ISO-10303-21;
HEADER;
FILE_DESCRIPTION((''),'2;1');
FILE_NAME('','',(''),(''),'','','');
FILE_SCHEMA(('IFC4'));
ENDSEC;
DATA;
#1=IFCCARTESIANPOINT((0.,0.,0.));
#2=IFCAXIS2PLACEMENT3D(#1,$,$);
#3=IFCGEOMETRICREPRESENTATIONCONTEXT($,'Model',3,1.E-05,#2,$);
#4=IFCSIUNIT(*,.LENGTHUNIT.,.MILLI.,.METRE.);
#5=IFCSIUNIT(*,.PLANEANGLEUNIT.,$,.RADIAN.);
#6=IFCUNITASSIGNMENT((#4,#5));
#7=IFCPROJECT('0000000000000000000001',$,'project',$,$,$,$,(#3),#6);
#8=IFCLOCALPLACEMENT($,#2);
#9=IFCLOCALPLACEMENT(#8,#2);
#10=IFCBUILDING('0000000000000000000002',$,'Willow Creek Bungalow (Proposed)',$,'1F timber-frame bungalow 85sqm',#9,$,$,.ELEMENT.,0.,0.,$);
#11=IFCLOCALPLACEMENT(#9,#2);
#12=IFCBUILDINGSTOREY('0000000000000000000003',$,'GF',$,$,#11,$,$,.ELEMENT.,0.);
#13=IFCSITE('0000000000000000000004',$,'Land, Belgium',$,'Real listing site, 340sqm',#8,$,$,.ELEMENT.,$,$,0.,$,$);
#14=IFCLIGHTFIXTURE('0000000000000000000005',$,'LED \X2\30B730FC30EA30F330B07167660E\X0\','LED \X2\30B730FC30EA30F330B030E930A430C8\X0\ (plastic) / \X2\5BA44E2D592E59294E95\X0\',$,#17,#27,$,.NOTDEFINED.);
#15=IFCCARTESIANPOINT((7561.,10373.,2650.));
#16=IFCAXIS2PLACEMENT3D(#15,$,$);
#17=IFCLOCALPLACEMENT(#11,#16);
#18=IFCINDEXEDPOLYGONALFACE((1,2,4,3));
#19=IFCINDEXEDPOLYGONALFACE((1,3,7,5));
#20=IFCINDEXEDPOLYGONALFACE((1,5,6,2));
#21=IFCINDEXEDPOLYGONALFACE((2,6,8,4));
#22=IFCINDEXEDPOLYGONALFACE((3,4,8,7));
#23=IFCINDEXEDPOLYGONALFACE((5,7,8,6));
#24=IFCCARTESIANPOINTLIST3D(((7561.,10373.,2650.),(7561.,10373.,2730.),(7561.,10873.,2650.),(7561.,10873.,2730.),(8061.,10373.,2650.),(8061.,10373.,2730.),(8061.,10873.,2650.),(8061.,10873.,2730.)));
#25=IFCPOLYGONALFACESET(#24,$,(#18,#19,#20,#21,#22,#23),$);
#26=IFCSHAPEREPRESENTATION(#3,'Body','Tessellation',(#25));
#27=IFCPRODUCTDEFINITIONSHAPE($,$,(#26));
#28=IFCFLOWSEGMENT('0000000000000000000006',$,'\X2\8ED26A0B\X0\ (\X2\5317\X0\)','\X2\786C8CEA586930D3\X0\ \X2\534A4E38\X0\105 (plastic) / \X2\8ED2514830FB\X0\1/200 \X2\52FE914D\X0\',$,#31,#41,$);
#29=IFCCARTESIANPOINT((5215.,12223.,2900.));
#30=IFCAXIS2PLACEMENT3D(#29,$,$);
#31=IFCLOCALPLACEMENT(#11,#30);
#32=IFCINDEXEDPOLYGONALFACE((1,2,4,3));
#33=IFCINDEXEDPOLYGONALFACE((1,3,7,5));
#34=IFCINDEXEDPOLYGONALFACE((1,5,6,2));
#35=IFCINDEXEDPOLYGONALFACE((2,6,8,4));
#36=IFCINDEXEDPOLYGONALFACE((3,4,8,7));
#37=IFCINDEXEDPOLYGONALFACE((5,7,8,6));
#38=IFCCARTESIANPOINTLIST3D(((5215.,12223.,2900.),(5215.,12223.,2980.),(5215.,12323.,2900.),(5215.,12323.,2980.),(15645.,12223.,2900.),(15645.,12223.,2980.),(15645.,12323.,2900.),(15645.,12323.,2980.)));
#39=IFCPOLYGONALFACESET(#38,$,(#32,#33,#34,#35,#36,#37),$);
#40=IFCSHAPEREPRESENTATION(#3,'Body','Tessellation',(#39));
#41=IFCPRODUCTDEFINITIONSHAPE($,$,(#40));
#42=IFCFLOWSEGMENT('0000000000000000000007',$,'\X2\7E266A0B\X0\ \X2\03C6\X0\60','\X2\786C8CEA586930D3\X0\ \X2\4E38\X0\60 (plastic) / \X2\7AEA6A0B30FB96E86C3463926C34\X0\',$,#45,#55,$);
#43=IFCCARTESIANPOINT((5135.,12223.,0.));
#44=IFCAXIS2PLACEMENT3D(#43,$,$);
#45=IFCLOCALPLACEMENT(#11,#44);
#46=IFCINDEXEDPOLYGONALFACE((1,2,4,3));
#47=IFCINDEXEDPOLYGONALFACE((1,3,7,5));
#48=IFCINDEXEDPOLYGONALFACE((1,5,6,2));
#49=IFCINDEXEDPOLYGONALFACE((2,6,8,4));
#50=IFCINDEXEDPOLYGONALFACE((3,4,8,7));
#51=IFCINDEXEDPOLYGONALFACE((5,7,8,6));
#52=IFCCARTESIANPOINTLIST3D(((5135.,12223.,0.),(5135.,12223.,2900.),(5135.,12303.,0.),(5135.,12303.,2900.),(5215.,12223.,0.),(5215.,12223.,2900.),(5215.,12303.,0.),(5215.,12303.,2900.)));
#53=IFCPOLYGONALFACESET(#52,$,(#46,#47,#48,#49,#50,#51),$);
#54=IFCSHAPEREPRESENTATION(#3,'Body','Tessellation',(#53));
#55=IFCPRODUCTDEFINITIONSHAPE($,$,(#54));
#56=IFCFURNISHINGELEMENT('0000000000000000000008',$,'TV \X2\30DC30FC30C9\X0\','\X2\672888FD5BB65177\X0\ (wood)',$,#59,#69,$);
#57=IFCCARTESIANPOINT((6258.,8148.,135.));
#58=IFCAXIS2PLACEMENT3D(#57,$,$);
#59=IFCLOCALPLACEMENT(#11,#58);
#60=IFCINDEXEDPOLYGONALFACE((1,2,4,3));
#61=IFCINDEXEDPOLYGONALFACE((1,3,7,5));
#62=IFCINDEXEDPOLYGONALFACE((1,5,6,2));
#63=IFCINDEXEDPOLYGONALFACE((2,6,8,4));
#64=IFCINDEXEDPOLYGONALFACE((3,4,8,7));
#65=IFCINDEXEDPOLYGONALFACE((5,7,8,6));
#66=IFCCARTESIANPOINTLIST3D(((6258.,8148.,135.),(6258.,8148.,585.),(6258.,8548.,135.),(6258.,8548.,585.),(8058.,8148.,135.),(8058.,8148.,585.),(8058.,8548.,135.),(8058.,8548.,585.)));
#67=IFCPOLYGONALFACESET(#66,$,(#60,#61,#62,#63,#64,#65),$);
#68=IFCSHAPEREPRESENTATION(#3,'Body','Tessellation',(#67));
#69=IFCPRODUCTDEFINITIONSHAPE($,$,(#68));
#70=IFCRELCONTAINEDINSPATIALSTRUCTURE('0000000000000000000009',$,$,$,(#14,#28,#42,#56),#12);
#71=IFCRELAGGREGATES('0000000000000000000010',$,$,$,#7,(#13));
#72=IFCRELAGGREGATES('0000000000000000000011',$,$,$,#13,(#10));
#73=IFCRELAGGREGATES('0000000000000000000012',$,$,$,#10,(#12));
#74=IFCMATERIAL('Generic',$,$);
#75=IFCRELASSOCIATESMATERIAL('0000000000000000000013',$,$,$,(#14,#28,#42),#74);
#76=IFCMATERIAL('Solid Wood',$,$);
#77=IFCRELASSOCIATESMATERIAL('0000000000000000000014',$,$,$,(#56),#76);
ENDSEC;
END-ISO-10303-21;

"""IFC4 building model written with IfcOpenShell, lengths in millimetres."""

from ifc_helpers import new_model, si_unit, frame, frame_2d, origin, place, context, project, spatial, rectangle, extrude, material, element, save


model = new_model("IFC4")

# Units and contexts
model_context = context("Model", 3, precision=1e-05, world=origin())
ifc_project = project(units=[si_unit("LENGTHUNIT", "METRE", prefix="MILLI"), si_unit("PLANEANGLEUNIT", "RADIAN")], contexts=[model_context])

# Site, building, storey
site_placement = place(None, origin())
site = spatial("IfcSite", under=ifc_project, at=site_placement, Name="Land, Belgium", ObjectType="Real listing site, 340sqm", CompositionType="ELEMENT", RefElevation=0.0)
building_placement = place(site_placement, origin())
building = spatial("IfcBuilding", under=site, at=building_placement, Name="Willow Creek Bungalow (Proposed)", ObjectType="1F timber-frame bungalow 85sqm", CompositionType="ELEMENT", ElevationOfRefHeight=0.0, ElevationOfTerrain=0.0)
storey_placement = place(building_placement, origin())
storey = spatial("IfcBuildingStorey", under=building, at=storey_placement, Name="GF", CompositionType="ELEMENT", Elevation=0.0)

# Shared definitions
ifc_material_1 = material(Name="Solid Wood")

# Shared definitions
ifc_material_2 = material(Name="Generic")

# Light fixture
light_fixture_placement = place(storey_placement, frame((7561.0, 10373.0, 2650.0)))
element("IfcLightFixture", 1, at=light_fixture_placement, inside=storey, material=ifc_material_2, Name="LED シーリング照明", Description="LED シーリングライト (plastic) / 室中央天井", PredefinedType="NOTDEFINED", context=model_context, shape_type="SweptSolid", body=[
    extrude(rectangle(XDim=500.0, YDim=500.0, at=frame_2d((250.0, 250.0))), frame((7561.0, 10373.0, 2650.0)), (0.0, 0.0, 1.0), 80.0),
])

# Flow segments
flow_segment_1_placement = place(storey_placement, frame((5215.0, 12223.0, 2900.0)))
element("IfcFlowSegment", 2, at=flow_segment_1_placement, inside=storey, material=ifc_material_2, Name="軒樋 (北)", Description="硬質塩ビ 半丸105 (plastic) / 軒先・1/200 勾配", context=model_context, shape_type="SweptSolid", body=[
    extrude(rectangle(XDim=10430.0, YDim=100.0, at=frame_2d((5215.0, 50.0))), frame((5215.0, 12223.0, 2900.0)), (0.0, 0.0, 1.0), 80.0),
])
flow_segment_2_placement = place(storey_placement, frame((5135.0, 12223.0, 0.0)))
element("IfcFlowSegment", 3, at=flow_segment_2_placement, inside=storey, material=ifc_material_2, Name="縦樋 φ60", Description="硬質塩ビ 丸60 (plastic) / 竪樋・雨水排水", context=model_context, shape_type="SweptSolid", body=[
    extrude(rectangle(XDim=80.0, YDim=80.0, at=frame_2d((40.0, 40.0))), frame((5135.0, 12223.0, 0.0)), (0.0, 0.0, 1.0), 2900.0),
])

# Furnishing element
furnishing_placement = place(storey_placement, frame((6258.0, 8148.0, 135.0)))
element("IfcFurnishingElement", 4, at=furnishing_placement, inside=storey, material=ifc_material_1, Name="TV ボード", Description="木製家具 (wood)", context=model_context, shape_type="SweptSolid", body=[
    extrude(rectangle(XDim=1800.0, YDim=400.0, at=frame_2d((900.0, 200.0))), frame((6258.0, 8148.0, 135.0)), (0.0, 0.0, 1.0), 450.0),
])

save(model, "model.ifc")
